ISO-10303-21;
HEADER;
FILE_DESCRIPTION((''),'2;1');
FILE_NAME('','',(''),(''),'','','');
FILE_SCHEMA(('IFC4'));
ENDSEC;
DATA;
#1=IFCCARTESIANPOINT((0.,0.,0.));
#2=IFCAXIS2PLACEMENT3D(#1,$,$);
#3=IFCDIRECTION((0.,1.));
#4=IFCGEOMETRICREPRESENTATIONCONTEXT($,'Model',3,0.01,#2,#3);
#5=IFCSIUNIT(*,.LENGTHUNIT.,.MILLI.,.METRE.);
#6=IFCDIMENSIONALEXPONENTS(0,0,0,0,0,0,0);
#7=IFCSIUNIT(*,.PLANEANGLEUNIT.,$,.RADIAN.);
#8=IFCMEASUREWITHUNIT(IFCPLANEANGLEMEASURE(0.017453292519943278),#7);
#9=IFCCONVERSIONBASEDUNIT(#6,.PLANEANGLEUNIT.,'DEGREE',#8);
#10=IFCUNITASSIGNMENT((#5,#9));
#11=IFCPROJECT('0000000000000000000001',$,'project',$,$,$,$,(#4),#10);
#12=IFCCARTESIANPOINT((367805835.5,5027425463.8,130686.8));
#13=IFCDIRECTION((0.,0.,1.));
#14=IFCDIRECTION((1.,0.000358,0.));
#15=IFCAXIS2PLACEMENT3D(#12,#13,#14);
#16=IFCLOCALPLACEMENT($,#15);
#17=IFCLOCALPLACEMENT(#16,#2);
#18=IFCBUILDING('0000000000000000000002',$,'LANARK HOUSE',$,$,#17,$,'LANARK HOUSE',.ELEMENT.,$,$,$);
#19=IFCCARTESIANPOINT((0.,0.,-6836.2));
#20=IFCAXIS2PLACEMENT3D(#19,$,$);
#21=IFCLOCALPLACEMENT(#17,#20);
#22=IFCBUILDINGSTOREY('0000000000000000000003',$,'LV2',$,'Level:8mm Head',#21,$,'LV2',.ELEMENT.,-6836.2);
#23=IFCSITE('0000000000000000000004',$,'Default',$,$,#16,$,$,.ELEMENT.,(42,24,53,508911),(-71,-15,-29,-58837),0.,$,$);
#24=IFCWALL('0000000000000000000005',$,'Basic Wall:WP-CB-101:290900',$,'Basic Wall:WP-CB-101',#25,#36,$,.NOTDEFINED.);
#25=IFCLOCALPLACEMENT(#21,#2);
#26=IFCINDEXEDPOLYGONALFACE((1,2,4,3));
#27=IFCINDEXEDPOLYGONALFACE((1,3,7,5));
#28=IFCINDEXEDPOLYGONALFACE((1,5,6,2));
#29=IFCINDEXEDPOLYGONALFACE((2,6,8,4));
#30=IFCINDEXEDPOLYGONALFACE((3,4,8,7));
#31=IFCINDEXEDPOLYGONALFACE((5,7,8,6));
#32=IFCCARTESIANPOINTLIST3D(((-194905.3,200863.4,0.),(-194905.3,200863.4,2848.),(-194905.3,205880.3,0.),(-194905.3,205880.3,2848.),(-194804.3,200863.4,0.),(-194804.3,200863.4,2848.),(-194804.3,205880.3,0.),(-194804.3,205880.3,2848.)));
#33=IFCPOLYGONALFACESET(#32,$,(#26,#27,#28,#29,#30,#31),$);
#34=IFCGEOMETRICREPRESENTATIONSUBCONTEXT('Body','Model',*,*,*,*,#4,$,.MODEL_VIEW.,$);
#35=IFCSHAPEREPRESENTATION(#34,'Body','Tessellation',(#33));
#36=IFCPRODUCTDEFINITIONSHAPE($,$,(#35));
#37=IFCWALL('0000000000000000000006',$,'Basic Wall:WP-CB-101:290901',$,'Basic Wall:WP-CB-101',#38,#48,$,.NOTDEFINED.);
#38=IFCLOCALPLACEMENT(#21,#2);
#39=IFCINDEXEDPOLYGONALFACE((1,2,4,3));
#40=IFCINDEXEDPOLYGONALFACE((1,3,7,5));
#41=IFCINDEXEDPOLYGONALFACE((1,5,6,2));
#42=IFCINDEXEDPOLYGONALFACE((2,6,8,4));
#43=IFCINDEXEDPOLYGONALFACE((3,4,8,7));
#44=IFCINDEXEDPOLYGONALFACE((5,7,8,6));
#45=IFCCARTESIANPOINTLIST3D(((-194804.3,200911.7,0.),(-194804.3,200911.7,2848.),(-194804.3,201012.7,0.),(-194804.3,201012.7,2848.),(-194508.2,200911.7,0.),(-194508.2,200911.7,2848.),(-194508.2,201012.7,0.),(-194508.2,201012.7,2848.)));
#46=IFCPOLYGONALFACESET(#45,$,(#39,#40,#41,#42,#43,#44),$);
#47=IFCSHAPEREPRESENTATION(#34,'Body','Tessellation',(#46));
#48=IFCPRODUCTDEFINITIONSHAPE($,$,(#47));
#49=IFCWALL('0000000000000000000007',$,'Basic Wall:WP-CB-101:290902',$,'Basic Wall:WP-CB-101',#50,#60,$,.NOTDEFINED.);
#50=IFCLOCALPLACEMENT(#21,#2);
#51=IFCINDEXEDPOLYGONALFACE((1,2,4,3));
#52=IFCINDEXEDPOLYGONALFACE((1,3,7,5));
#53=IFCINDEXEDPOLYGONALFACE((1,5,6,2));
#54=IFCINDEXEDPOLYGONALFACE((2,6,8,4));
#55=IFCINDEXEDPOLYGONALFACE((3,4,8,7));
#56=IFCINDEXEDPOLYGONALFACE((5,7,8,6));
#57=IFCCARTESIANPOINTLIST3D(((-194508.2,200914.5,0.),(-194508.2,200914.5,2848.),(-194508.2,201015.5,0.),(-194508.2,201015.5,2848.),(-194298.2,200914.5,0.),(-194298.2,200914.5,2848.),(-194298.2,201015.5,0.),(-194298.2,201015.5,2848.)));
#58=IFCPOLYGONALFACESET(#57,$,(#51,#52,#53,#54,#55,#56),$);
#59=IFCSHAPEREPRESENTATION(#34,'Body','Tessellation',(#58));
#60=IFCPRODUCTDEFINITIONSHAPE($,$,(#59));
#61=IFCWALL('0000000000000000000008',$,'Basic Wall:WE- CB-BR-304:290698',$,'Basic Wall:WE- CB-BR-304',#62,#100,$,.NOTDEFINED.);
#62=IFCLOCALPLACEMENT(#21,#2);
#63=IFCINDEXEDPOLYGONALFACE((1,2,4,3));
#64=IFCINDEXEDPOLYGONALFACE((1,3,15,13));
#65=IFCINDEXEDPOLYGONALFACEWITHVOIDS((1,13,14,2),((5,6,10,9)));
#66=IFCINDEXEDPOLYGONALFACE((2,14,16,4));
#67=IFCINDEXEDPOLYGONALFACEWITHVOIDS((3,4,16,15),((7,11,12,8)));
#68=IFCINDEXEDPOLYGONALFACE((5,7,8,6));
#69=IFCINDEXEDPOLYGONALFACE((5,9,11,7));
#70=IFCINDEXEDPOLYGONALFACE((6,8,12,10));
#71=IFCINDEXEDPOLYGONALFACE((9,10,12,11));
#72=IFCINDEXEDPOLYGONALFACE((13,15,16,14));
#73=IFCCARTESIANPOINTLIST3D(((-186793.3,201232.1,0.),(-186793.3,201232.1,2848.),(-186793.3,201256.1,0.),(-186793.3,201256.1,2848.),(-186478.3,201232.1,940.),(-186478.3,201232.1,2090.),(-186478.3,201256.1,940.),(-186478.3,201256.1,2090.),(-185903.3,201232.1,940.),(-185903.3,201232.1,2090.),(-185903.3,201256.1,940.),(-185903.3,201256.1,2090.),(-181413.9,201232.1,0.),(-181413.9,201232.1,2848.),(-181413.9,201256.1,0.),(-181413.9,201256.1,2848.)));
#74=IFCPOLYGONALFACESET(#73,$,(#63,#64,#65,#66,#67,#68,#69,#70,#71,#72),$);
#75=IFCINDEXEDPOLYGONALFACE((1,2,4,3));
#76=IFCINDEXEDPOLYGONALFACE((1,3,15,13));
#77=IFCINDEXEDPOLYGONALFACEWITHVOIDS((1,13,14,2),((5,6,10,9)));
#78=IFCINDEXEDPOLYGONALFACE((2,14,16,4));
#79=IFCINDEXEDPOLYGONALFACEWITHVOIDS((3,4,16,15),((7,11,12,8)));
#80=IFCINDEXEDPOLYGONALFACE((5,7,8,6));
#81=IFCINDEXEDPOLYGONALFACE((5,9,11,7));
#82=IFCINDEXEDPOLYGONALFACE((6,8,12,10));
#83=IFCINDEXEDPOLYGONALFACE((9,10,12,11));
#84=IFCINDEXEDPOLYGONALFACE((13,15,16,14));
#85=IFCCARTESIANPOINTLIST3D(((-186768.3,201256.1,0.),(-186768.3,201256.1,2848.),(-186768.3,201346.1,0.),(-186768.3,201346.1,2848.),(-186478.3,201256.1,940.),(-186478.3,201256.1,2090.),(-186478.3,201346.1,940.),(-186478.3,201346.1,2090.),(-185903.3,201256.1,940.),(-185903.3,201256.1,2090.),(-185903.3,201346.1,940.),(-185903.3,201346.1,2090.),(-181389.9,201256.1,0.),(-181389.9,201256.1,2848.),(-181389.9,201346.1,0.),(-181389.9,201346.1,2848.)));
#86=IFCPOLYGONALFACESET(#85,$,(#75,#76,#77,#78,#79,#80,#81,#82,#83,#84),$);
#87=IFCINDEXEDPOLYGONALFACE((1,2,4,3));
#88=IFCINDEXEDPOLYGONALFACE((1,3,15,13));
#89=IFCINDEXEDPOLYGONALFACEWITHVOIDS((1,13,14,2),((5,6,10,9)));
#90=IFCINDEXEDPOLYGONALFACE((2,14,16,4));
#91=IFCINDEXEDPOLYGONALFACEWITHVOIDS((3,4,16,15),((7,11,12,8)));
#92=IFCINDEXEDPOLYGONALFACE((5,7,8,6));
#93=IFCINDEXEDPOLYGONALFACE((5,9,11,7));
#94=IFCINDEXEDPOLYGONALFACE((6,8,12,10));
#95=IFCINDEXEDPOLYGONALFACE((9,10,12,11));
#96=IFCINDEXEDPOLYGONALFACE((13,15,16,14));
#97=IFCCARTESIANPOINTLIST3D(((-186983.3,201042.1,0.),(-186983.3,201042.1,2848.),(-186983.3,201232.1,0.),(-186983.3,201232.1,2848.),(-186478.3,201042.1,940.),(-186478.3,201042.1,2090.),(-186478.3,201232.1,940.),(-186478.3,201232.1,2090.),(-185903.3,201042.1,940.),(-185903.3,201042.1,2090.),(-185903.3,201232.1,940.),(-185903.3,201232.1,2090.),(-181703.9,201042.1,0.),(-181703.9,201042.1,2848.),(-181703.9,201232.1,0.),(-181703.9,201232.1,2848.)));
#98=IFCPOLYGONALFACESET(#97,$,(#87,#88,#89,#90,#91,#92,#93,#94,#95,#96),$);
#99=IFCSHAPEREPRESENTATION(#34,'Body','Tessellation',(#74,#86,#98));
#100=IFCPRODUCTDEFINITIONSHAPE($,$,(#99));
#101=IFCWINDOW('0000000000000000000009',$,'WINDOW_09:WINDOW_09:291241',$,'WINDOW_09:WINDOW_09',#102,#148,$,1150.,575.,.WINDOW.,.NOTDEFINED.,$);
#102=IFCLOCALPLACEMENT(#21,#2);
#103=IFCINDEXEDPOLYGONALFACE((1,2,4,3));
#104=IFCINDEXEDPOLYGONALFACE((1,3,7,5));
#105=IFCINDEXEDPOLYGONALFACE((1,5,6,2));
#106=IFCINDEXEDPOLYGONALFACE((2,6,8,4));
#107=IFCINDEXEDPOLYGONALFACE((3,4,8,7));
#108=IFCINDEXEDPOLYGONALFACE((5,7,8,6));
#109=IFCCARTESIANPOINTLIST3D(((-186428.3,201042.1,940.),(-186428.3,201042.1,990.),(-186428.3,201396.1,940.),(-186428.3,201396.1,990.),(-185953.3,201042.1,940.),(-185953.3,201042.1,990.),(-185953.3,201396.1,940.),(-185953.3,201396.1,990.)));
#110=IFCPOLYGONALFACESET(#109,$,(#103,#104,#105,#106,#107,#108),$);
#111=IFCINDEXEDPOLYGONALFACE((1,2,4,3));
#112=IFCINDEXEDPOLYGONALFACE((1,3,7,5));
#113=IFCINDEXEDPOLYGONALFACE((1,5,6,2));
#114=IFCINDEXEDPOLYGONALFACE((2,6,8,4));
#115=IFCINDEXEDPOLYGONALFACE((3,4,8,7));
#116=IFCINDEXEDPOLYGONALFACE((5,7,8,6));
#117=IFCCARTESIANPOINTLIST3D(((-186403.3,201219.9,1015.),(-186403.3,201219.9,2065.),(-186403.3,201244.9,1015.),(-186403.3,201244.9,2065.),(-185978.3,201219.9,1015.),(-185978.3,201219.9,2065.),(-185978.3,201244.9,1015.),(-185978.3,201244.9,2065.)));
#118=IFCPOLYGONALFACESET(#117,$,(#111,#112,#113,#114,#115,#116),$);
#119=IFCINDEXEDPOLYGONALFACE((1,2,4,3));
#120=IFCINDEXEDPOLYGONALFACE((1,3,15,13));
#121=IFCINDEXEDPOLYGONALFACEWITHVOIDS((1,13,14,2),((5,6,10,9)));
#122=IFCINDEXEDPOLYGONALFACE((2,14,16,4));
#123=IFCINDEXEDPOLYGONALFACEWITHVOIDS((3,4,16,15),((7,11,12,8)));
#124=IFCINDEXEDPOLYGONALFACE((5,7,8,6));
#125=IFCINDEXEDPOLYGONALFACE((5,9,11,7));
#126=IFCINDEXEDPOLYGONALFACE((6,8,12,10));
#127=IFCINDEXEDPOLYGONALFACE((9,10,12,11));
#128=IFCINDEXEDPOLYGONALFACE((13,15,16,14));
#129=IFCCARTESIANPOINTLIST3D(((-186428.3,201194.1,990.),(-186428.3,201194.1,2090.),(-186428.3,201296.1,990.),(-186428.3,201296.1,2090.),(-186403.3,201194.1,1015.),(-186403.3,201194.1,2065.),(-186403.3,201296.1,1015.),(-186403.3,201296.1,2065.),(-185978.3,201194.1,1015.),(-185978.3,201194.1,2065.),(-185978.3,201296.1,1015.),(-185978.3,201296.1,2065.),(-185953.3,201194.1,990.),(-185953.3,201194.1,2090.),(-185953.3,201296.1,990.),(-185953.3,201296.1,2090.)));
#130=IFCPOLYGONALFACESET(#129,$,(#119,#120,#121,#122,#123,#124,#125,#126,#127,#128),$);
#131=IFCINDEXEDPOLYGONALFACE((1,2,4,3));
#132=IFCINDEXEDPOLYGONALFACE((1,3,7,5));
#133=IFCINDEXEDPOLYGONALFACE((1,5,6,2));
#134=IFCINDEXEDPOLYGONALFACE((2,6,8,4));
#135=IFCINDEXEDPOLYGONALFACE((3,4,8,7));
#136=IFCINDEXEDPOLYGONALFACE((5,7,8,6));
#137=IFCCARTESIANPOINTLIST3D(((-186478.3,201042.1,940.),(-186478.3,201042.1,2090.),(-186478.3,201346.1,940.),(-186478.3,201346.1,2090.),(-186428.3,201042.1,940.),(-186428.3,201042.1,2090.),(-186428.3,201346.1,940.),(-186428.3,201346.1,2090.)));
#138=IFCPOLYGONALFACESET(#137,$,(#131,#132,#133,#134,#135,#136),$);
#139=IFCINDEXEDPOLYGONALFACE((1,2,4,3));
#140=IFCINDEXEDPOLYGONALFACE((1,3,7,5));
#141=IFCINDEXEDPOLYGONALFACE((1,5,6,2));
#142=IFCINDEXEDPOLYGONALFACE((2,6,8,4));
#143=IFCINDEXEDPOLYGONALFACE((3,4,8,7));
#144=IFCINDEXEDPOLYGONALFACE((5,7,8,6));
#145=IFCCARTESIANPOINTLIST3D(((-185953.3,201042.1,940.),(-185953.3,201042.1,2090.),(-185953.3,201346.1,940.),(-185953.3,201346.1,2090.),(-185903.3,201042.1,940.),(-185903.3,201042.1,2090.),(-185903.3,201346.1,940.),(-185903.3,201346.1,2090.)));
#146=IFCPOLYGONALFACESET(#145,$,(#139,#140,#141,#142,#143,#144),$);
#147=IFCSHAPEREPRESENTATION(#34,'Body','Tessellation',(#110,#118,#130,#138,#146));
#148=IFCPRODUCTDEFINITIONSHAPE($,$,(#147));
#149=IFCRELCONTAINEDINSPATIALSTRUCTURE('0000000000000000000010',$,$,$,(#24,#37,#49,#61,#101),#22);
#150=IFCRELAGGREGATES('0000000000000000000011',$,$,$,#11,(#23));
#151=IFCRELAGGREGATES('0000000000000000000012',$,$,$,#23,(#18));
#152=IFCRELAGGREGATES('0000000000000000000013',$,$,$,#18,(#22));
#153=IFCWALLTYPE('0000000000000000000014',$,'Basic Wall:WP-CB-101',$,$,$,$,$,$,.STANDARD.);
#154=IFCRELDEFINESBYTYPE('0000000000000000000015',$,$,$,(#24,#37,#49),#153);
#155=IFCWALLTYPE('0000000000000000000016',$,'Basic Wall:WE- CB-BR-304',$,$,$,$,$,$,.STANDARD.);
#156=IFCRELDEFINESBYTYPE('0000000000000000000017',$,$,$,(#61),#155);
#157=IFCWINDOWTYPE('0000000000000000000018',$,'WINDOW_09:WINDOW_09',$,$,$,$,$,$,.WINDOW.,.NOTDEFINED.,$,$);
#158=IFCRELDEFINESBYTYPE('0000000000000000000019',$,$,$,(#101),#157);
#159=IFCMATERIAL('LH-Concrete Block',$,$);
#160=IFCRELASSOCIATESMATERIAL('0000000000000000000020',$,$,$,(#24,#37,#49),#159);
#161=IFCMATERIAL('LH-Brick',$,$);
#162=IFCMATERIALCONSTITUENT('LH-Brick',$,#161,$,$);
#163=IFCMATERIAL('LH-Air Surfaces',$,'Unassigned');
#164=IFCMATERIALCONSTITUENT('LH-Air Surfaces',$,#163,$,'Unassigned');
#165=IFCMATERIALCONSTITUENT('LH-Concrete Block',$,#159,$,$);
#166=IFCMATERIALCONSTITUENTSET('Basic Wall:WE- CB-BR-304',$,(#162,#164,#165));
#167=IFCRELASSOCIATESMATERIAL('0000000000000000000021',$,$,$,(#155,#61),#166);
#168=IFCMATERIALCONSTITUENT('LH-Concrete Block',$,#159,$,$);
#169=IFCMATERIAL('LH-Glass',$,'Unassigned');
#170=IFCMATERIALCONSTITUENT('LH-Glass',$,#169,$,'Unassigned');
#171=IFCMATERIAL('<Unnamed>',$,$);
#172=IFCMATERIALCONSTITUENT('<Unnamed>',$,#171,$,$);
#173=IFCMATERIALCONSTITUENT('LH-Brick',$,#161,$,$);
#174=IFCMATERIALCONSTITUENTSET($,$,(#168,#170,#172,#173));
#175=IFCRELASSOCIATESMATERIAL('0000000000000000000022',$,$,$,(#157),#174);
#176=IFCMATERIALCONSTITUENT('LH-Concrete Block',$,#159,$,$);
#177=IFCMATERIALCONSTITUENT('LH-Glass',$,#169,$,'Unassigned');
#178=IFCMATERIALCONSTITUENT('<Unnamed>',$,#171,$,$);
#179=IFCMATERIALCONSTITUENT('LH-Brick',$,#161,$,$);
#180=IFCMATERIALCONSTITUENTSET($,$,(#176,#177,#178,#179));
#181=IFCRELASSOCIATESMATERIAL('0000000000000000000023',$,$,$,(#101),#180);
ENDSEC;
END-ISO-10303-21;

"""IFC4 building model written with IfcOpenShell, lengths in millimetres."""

from ifc_helpers import new_model, entity, si_unit, converted_unit, direction, frame, origin, place, context, subcontext, project, spatial, indexed_curve, outline, extrude, source, transform, mapped, material, constituent, constituent_set, type_object, type_shapes, element, fill, save


model = new_model("IFC4")

# Units and contexts
model_context = context("Model", 3, precision=0.01, world=origin(), true_north=direction((0.0, 1.0)))
body_context = subcontext(model_context, "Body", "Model", "MODEL_VIEW")
ifc_project = project(units=[si_unit("LENGTHUNIT", "METRE", prefix="MILLI"), converted_unit("PLANEANGLEUNIT", "DEGREE", entity("IfcPlaneAngleMeasure", 0.017453292519943278), si_unit("PLANEANGLEUNIT", "RADIAN"), dimensions=[0, 0, 0, 0, 0, 0, 0])], contexts=[model_context])

# Site, building, storey
site_placement = place(None, frame((367805835.5, 5027425463.8, 130686.8), z_axis=(0.0, 0.0, 1.0), x_axis=(1.0, 0.000358, 0.0)))
site = spatial("IfcSite", under=ifc_project, at=site_placement, Name="Default", CompositionType="ELEMENT", RefLatitude=(42, 24, 53, 508911), RefLongitude=(-71, -15, -29, -58837), RefElevation=0.0)
building_placement = place(site_placement, origin())
building = spatial("IfcBuilding", under=site, at=building_placement, Name="LANARK HOUSE", LongName="LANARK HOUSE", CompositionType="ELEMENT")
storey_placement = place(building_placement, frame((0.0, 0.0, -6836.2)))
storey = spatial("IfcBuildingStorey", under=building, at=storey_placement, Name="LV2", ObjectType="Level:8mm Head", LongName="LV2", CompositionType="ELEMENT", Elevation=-6836.2)

# Shared definitions
ifc_material_1 = material(Name="<Unnamed>")

# Shared definitions
ifc_material_2 = material(Name="LH-Glass", Category="Unassigned")

# Walls
ifc_material_3 = material(Name="LH-Brick")
ifc_material_4 = material(Name="LH-Air Surfaces", Category="Unassigned")
ifc_material_5 = material(Name="LH-Concrete Block")
wall_type_1 = type_object("IfcWallType", Name="Basic Wall:WP-CB-101", PredefinedType="STANDARD")
wall_1_placement = place(storey_placement, frame((-194854.8, 200863.4, 0.0), z_axis=(0.0, 0.0, 1.0), x_axis=(0.0, 1.0, 0.0)))
element("IfcWall", 1, at=wall_1_placement, inside=storey, type_object=wall_type_1, material=ifc_material_5, Name="Basic Wall:WP-CB-101:290900", ObjectType="Basic Wall:WP-CB-101", PredefinedType="NOTDEFINED", context=body_context, shape_type="SweptSolid", body=[
    extrude(outline(indexed_curve([(5016.9, 50.5), (0.0, 50.5), (0.0, -50.5), (5016.9, -50.5), (5016.9, 50.5)], self_intersect=False)), origin(), (0.0, 0.0, 1.0), 2848.0),
])
wall_2_placement = place(storey_placement, frame((-194508.2, 200962.2, 0.0), z_axis=(0.0, 0.0, 1.0), x_axis=(-1.0, 0.0, 0.0)))
element("IfcWall", 2, at=wall_2_placement, inside=storey, type_object=wall_type_1, material=ifc_material_5, Name="Basic Wall:WP-CB-101:290901", ObjectType="Basic Wall:WP-CB-101", PredefinedType="NOTDEFINED", context=body_context, shape_type="SweptSolid", body=[
    extrude(outline(indexed_curve([(296.1, 50.5), (0.0, 50.5), (0.0, -50.5), (296.1, -50.5), (296.1, 50.5)], self_intersect=False)), origin(), (0.0, 0.0, 1.0), 2848.0),
])
wall_3_placement = place(storey_placement, frame((-194298.2, 200965.0, 0.0), z_axis=(0.0, 0.0, 1.0), x_axis=(-1.0, 0.0, 0.0)))
element("IfcWall", 3, at=wall_3_placement, inside=storey, type_object=wall_type_1, material=ifc_material_5, Name="Basic Wall:WP-CB-101:290902", ObjectType="Basic Wall:WP-CB-101", PredefinedType="NOTDEFINED", context=body_context, shape_type="SweptSolid", body=[
    extrude(outline(indexed_curve([(210.0, 50.5), (0.0, 50.5), (0.0, -50.5), (210.0, -50.5), (210.0, 50.5)], self_intersect=False)), origin(), (0.0, 0.0, 1.0), 2848.0),
])

# Wall, opening, window
ifc_constituent_1 = constituent(ifc_material_3, Name="LH-Brick")
ifc_constituent_2 = constituent(ifc_material_4, Name="LH-Air Surfaces", Category="Unassigned")
ifc_constituent_3 = constituent(ifc_material_5, Name="LH-Concrete Block")
ifc_constituent_set_1 = constituent_set(constituents=[ifc_constituent_1, ifc_constituent_2, ifc_constituent_3], Name="Basic Wall:WE- CB-BR-304")
wall_type_2 = type_object("IfcWallType", Name="Basic Wall:WE- CB-BR-304", PredefinedType="STANDARD", material=ifc_constituent_set_1)
wall_4_placement = place(storey_placement, frame((-187109.3, 201194.1, 0.0)))
wall_4 = element("IfcWall", 4, at=wall_4_placement, inside=storey, type_object=wall_type_2, material=ifc_constituent_set_1, Name="Basic Wall:WE- CB-BR-304:290698", ObjectType="Basic Wall:WE- CB-BR-304", PredefinedType="NOTDEFINED", context=body_context, shape_type="SweptSolid", body=[
    extrude(outline(indexed_curve([(-1424.0, -2689.7), (1424.0, -2689.7), (1424.0, 2689.7), (-1424.0, 2689.7), (-1424.0, -2689.7)], self_intersect=False), holes=[indexed_curve([(666.0, -2374.7), (-484.0, -2374.7), (-484.0, -1799.7), (666.0, -1799.7), (666.0, -2374.7)], self_intersect=False)]), frame((3005.7, 38.0, 1424.0), z_axis=(0.0, 1.0, 0.0), x_axis=(0.0, 0.0, 1.0)), (0.0, 0.0, 1.0), 24.0),
    extrude(outline(indexed_curve([(-1424.0, -2689.2), (1424.0, -2689.2), (1424.0, 2689.2), (-1424.0, 2689.2), (-1424.0, -2689.2)], self_intersect=False), holes=[indexed_curve([(666.0, -2399.2), (-484.0, -2399.2), (-484.0, -1824.2), (666.0, -1824.2), (666.0, -2399.2)], self_intersect=False)]), frame((3030.2, 62.0, 1424.0), z_axis=(0.0, 1.0, 0.0), x_axis=(0.0, 0.0, 1.0)), (0.0, 0.0, 1.0), 90.0),
    extrude(outline(indexed_curve([(-1424.0, -2639.7), (1424.0, -2639.7), (1424.0, 2639.7), (-1424.0, 2639.7), (-1424.0, -2639.7)], self_intersect=False), holes=[indexed_curve([(666.0, -2134.7), (-484.0, -2134.7), (-484.0, -1559.7), (666.0, -1559.7), (666.0, -2134.7)], self_intersect=False)]), frame((2765.7, -152.0, 1424.0), z_axis=(0.0, 1.0, 0.0), x_axis=(0.0, 0.0, 1.0)), (0.0, 0.0, 1.0), 190.0),
])
opening_1_placement = place(wall_4_placement, frame((187109.3, -201194.1, 940.0)))
opening_1 = element("IfcOpeningElement", 5, at=opening_1_placement, cuts=wall_4, PredefinedType="OPENING", context=body_context, shape_type="SweptSolid", body=[
    extrude(outline(indexed_curve([(-575.0, -287.5), (575.0, -287.5), (575.0, 287.5), (-575.0, 287.5), (-575.0, -287.5)], self_intersect=False)), frame((-186190.8, 201042.1, 575.0), z_axis=(0.0, 1.0, 0.0), x_axis=(0.0, 0.0, -1.0)), (0.0, 0.0, 1.0), 304.0),
])
ifc_constituent_4 = constituent(ifc_material_5, Name="LH-Concrete Block")
ifc_constituent_5 = constituent(ifc_material_2, Name="LH-Glass", Category="Unassigned")
ifc_constituent_6 = constituent(ifc_material_1, Name="<Unnamed>")
ifc_constituent_7 = constituent(ifc_material_3, Name="LH-Brick")
ifc_constituent_set_2 = constituent_set(constituents=[ifc_constituent_4, ifc_constituent_5, ifc_constituent_6, ifc_constituent_7])
ifc_constituent_8 = constituent(ifc_material_5, Name="LH-Concrete Block")
ifc_constituent_9 = constituent(ifc_material_2, Name="LH-Glass", Category="Unassigned")
ifc_constituent_10 = constituent(ifc_material_1, Name="<Unnamed>")
ifc_constituent_11 = constituent(ifc_material_3, Name="LH-Brick")
ifc_constituent_set_3 = constituent_set(constituents=[ifc_constituent_8, ifc_constituent_9, ifc_constituent_10, ifc_constituent_11])
window_type = type_object("IfcWindowType", Name="WINDOW_09:WINDOW_09", PartitioningType="NOTDEFINED", PredefinedType="WINDOW", material=ifc_constituent_set_3)
shared_shape_1 = source(origin(), body_context, "Body", "SweptSolid", [
    extrude(outline(indexed_curve([(-177.0, -237.5), (177.0, -237.5), (177.0, 237.5), (-177.0, 237.5), (-177.0, -237.5)], self_intersect=False)), frame((287.5, -127.0, 0.0), z_axis=(0.0, 0.0, 1.0), x_axis=(0.0, -1.0, 0.0)), (0.0, 0.0, 1.0), 50.0),
    extrude(outline(indexed_curve([(-212.5, -12.5), (212.5, -12.5), (212.5, 12.5), (-212.5, 12.5), (-212.5, -12.5)], self_intersect=False)), frame((287.5, -113.7, 75.0), z_axis=(0.0, 0.0, 1.0), x_axis=(-1.0, 0.0, 0.0)), (0.0, 0.0, 1.0), 1050.0),
    extrude(outline(indexed_curve([(-237.5, -550.0), (237.5, -550.0), (237.5, 550.0), (-237.5, 550.0), (-237.5, -550.0)], self_intersect=False), holes=[indexed_curve([(-212.5, 525.0), (212.5, 525.0), (212.5, -525.0), (-212.5, -525.0), (-212.5, 525.0)], self_intersect=False)]), frame((287.5, -152.0, 600.0), z_axis=(0.0, 1.0, 0.0), x_axis=(1.0, 0.0, 0.0)), (0.0, 0.0, 1.0), 102.0),
    extrude(outline(indexed_curve([(-25.0, -152.0), (25.0, -152.0), (25.0, 152.0), (-25.0, 152.0), (-25.0, -152.0)], self_intersect=False)), frame((25.0, -152.0, 0.0), z_axis=(0.0, 0.0, 1.0), x_axis=(-1.0, 0.0, 0.0)), (0.0, 0.0, 1.0), 1150.0),
    extrude(outline(indexed_curve([(-25.0, -152.0), (25.0, -152.0), (25.0, 152.0), (-25.0, 152.0), (-25.0, -152.0)], self_intersect=False)), frame((550.0, -152.0, 0.0), z_axis=(0.0, 0.0, 1.0), x_axis=(-1.0, 0.0, 0.0)), (0.0, 0.0, 1.0), 1150.0),
])
type_shapes(window_type, [shared_shape_1])
window_placement = place(opening_1_placement, frame((-186478.3, 201346.1, 0.0)))
window = element("IfcWindow", 6, at=window_placement, inside=storey, type_object=window_type, material=ifc_constituent_set_2, Name="WINDOW_09:WINDOW_09:291241", ObjectType="WINDOW_09:WINDOW_09", OverallHeight=1150.0, OverallWidth=575.0, PartitioningType="NOTDEFINED", PredefinedType="WINDOW", context=body_context, shape_type="MappedRepresentation", body=[
    mapped(shared_shape_1, transform((0.0, 0.0, 0.0), scale=1.0)),
])
fill(opening_1, window)

save(model, "model.ifc")
